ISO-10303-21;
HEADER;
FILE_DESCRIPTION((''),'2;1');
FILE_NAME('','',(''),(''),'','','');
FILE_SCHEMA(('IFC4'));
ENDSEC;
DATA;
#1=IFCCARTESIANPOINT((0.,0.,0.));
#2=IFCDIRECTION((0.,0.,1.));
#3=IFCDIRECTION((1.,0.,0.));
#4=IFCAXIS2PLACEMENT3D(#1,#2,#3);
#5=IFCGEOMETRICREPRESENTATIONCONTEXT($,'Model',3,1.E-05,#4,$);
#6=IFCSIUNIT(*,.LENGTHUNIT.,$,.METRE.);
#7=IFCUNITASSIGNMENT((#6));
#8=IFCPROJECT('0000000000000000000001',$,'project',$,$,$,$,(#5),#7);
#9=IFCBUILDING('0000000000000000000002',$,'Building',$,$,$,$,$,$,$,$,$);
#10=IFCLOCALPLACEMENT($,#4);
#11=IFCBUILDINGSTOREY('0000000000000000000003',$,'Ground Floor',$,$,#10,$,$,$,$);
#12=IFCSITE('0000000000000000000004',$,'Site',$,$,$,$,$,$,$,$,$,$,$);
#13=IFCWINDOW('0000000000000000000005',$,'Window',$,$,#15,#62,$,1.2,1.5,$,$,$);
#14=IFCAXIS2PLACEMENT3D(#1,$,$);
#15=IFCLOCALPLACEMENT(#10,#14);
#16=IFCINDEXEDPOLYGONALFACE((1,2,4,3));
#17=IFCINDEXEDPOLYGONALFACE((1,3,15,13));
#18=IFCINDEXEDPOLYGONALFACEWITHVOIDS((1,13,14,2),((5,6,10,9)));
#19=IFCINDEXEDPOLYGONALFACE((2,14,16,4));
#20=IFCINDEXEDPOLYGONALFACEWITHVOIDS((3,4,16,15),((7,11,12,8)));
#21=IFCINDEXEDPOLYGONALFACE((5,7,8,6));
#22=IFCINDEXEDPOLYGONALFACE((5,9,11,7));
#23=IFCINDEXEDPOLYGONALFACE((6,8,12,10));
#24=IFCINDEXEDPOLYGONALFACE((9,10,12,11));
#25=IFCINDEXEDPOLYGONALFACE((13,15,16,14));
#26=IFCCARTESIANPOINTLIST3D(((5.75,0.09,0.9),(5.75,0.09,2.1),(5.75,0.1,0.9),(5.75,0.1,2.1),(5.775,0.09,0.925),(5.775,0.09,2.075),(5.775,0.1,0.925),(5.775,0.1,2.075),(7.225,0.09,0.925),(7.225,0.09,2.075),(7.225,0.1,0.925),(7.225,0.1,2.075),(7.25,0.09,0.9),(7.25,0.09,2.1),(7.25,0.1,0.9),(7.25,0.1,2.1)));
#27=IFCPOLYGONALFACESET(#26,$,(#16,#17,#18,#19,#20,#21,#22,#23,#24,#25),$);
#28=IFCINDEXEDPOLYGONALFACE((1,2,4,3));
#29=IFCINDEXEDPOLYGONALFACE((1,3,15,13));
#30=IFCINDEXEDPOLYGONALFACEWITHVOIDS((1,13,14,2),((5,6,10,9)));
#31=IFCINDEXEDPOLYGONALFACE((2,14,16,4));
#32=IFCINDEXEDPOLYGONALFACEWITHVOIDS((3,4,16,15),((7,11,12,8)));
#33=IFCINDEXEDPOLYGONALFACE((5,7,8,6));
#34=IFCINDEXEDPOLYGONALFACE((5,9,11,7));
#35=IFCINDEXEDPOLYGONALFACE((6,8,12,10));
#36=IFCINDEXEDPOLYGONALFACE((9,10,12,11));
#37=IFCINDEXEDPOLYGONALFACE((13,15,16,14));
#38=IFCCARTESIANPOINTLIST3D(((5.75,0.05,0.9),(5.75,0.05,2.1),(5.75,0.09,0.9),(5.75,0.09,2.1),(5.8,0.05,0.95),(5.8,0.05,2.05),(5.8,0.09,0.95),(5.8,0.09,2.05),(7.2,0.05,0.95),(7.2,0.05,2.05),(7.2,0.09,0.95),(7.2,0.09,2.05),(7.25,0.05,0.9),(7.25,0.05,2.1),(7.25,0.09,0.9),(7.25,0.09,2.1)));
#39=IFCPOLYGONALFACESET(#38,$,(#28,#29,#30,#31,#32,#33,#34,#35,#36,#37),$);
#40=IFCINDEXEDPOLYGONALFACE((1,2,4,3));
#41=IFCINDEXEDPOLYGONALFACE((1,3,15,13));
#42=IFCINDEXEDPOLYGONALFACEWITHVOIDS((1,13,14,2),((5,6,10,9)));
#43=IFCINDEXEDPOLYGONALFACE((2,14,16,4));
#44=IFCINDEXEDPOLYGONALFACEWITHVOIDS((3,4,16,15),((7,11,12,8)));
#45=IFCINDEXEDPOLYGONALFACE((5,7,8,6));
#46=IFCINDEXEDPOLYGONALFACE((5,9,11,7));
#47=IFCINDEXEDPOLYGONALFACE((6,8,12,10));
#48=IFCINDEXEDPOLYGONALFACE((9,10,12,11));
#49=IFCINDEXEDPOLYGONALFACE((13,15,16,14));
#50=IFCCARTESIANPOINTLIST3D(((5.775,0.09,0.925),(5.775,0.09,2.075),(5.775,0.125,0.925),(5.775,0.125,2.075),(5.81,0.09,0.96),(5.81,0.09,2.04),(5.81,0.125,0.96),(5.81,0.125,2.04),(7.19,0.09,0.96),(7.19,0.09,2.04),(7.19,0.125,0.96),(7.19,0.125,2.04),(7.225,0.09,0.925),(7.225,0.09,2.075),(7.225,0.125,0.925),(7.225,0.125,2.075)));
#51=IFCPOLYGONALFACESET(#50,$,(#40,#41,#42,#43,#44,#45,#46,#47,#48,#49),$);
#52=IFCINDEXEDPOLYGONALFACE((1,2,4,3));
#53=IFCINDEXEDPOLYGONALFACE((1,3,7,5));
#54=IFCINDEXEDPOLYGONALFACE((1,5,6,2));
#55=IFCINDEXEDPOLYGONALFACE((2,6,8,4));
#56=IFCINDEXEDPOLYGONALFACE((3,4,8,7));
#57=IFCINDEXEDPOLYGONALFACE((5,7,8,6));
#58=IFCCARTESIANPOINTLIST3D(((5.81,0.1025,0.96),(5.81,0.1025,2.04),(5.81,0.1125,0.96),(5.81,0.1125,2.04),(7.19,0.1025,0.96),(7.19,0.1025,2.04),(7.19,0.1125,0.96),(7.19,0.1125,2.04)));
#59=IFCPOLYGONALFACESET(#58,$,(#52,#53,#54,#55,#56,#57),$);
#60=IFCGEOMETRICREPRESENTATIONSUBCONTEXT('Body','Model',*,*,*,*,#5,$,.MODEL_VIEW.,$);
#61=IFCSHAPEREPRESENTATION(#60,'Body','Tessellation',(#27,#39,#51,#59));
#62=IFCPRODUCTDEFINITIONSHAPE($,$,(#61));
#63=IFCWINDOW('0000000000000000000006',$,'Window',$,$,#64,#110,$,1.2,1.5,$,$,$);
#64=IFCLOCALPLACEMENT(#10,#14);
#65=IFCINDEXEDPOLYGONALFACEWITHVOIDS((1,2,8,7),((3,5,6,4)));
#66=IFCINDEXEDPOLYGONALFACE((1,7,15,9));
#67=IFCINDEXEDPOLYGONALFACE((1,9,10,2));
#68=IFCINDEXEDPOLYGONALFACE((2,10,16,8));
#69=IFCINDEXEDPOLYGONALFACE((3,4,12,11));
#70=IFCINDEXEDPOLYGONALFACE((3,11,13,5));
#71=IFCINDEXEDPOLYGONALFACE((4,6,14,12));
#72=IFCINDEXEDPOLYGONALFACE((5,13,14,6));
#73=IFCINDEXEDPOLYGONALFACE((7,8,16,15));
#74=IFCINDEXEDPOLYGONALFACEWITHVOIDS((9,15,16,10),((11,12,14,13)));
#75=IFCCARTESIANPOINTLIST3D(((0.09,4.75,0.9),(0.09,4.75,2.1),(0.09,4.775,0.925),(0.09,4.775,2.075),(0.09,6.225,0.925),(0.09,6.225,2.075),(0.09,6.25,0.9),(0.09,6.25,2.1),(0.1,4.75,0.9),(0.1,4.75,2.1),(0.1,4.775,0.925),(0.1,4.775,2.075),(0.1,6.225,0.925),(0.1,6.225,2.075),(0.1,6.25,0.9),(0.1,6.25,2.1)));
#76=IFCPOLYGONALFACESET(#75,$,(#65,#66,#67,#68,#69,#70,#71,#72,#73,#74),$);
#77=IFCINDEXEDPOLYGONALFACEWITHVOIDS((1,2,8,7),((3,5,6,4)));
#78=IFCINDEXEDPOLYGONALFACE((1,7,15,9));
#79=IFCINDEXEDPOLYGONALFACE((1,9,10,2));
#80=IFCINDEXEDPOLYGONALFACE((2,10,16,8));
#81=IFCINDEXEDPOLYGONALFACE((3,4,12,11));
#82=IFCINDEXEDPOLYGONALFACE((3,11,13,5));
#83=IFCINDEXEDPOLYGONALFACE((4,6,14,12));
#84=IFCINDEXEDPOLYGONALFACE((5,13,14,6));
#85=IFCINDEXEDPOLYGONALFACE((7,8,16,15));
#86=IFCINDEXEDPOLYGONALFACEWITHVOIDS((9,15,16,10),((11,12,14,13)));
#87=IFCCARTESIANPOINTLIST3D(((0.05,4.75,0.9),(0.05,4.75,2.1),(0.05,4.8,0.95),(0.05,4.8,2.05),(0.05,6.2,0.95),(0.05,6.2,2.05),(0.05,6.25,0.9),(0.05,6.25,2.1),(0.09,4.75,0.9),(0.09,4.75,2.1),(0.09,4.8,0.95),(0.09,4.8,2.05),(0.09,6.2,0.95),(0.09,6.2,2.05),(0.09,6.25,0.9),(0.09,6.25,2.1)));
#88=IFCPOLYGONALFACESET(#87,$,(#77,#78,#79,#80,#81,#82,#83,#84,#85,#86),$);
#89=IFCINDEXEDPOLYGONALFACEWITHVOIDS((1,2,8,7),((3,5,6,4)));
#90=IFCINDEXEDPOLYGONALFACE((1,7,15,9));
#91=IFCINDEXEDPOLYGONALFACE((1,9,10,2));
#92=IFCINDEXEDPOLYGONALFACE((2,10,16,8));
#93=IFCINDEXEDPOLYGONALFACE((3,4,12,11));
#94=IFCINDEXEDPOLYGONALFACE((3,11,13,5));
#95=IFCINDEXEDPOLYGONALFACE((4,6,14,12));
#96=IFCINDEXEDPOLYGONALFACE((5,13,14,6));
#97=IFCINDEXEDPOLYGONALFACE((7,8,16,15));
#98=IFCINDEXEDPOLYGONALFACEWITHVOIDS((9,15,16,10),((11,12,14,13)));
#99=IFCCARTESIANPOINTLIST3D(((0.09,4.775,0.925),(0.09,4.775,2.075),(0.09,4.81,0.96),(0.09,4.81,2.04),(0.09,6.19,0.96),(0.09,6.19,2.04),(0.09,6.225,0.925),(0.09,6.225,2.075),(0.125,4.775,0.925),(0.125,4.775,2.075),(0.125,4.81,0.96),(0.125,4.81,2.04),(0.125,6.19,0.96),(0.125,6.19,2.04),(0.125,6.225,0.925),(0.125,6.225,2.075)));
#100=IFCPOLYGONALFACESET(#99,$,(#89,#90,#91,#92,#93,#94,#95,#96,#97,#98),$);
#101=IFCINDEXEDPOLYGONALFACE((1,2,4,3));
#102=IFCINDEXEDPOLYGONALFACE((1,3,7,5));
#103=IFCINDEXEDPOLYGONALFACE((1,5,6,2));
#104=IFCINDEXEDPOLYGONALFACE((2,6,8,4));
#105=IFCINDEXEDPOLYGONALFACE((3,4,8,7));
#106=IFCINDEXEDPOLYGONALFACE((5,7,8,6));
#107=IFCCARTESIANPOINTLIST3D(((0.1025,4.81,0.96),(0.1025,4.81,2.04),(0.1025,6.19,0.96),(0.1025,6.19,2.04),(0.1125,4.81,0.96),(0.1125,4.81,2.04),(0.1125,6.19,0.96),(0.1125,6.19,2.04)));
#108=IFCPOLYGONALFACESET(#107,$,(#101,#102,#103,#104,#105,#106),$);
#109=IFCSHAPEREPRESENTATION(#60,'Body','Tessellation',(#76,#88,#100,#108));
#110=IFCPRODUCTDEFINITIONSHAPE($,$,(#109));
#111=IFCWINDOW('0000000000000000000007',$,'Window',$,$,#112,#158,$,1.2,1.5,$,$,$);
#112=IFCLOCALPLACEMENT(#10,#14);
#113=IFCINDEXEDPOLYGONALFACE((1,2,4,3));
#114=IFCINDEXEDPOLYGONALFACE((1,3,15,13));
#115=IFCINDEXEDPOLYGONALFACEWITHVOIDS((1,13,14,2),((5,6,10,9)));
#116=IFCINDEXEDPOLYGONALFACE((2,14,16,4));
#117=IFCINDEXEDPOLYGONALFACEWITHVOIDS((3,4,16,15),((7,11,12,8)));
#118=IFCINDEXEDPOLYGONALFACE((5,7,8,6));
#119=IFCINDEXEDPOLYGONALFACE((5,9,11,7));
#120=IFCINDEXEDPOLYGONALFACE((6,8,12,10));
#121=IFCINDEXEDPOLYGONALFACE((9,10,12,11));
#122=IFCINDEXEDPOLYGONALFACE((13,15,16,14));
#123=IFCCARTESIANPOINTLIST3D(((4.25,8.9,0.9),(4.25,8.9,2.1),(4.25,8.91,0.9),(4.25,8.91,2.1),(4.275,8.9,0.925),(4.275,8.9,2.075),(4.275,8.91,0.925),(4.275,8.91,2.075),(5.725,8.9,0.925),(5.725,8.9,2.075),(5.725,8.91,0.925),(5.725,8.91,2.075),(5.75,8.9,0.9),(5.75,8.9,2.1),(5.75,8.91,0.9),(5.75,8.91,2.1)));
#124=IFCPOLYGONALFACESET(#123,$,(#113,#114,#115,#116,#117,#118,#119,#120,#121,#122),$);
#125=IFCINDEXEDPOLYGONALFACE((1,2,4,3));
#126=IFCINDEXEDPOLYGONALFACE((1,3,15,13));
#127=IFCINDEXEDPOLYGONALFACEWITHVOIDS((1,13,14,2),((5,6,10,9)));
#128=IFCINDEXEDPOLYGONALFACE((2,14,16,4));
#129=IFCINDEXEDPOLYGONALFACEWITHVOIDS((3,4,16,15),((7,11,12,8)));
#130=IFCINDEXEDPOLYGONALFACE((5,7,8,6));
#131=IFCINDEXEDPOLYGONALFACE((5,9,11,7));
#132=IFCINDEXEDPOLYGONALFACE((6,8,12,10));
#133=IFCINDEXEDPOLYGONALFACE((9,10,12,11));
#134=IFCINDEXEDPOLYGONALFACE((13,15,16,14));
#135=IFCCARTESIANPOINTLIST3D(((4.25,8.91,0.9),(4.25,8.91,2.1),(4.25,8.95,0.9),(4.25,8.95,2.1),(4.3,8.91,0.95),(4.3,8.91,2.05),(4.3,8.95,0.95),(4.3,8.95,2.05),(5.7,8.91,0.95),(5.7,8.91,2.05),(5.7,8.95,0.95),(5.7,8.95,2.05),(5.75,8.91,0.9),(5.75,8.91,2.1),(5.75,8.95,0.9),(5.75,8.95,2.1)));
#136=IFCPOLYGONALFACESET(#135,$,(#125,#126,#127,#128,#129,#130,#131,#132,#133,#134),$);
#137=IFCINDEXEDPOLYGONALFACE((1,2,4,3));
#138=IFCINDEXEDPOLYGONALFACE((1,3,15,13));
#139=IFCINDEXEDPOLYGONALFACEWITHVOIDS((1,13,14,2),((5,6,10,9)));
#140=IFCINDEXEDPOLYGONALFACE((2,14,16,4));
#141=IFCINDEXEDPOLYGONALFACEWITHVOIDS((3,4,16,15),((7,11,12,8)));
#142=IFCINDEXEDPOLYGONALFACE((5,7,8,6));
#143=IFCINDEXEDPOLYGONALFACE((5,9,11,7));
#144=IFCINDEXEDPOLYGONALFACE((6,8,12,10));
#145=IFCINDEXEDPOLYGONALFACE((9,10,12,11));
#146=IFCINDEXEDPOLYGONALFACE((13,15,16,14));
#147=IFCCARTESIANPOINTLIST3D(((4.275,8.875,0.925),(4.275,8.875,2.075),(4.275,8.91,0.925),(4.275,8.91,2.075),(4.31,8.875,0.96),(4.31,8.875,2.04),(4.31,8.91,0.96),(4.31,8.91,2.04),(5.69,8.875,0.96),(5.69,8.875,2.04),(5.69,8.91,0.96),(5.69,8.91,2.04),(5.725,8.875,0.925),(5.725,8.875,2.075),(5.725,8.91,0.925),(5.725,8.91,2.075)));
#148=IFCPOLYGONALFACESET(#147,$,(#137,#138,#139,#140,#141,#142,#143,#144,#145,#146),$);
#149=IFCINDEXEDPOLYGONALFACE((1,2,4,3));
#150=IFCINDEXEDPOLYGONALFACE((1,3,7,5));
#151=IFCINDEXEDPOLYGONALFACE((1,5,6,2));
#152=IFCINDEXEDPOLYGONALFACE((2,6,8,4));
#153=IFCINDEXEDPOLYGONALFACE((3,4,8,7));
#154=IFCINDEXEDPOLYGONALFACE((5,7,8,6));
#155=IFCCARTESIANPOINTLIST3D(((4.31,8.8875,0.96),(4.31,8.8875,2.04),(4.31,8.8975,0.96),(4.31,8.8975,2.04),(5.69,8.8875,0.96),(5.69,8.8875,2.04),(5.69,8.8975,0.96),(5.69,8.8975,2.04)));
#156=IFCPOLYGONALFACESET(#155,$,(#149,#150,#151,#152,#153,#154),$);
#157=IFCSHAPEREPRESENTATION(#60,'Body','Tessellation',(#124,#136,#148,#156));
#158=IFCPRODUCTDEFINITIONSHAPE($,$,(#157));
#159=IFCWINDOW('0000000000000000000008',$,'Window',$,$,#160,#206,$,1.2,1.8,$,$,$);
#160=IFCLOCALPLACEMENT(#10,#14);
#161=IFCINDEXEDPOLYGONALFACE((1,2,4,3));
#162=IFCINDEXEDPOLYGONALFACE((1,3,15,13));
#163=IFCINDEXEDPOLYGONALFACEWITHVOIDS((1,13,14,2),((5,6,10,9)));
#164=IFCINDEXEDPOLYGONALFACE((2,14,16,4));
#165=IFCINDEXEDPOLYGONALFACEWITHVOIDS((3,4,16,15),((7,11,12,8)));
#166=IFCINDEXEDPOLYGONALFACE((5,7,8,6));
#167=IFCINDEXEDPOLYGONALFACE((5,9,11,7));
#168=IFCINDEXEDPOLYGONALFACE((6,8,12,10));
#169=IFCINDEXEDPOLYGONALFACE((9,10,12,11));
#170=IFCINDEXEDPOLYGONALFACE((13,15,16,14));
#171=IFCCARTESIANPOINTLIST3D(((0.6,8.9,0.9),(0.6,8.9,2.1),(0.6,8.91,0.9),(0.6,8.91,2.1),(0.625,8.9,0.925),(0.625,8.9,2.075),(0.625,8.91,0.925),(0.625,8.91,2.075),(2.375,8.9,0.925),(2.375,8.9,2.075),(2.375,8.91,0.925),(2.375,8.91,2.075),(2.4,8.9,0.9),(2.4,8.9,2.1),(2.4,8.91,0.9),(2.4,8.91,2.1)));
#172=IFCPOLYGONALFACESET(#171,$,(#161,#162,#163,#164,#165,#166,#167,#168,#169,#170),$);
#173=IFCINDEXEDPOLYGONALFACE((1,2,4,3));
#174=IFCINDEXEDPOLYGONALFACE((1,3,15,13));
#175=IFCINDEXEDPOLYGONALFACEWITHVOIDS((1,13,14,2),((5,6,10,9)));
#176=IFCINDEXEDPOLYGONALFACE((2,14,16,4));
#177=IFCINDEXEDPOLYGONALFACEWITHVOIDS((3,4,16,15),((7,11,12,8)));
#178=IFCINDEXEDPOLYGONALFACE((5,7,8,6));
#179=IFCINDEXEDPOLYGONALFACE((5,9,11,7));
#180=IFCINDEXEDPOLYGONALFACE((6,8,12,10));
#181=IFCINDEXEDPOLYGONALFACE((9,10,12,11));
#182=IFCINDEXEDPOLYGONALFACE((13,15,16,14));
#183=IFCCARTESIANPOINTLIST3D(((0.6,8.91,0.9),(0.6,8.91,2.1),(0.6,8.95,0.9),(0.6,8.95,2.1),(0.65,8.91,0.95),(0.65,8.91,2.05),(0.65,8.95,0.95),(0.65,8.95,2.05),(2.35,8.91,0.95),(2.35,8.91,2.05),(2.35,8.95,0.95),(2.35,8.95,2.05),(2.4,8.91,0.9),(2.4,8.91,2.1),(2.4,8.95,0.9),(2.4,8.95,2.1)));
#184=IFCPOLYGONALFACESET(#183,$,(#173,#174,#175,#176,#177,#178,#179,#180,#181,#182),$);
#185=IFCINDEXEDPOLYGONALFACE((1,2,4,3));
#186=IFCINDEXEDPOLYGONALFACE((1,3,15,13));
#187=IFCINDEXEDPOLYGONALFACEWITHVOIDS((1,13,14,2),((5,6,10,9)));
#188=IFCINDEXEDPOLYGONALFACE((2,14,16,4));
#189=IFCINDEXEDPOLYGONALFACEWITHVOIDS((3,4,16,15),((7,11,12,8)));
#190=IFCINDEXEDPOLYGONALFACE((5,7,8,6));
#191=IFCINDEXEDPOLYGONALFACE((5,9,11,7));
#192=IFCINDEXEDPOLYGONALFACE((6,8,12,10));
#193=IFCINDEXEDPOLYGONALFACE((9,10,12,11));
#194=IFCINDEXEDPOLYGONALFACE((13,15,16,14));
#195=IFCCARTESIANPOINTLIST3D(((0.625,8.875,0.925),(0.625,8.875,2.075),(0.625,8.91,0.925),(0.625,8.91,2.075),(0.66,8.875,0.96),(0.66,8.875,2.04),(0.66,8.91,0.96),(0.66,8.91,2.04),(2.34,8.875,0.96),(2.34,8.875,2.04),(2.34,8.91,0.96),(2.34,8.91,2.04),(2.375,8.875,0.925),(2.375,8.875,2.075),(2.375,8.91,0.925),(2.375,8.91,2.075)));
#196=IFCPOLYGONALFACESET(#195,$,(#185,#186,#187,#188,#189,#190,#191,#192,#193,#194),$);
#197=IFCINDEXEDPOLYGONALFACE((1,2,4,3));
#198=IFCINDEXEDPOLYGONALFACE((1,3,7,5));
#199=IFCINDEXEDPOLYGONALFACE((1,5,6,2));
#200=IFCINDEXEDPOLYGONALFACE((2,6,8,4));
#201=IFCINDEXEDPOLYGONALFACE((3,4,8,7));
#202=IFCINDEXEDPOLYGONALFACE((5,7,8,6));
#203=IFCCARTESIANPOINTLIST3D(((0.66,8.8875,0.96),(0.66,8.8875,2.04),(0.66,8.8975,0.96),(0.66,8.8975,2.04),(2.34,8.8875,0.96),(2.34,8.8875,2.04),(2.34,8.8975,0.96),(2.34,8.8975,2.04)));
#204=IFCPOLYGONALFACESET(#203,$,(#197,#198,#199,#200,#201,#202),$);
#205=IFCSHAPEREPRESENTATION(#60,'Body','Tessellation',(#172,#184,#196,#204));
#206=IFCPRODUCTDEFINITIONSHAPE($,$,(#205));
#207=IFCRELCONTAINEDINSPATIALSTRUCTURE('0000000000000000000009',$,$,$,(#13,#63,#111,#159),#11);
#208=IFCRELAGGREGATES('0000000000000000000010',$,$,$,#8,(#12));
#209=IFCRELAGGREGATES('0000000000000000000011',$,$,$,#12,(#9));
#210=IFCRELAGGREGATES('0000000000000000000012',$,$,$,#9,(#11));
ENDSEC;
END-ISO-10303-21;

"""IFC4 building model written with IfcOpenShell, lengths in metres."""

from ifc_helpers import new_model, si_unit, frame, origin_with_axes, place, context, subcontext, project, spatial, line, indexed_curve, outline, extrude, element, save


model = new_model("IFC4")

# Units and contexts
model_context = context("Model", 3, precision=1e-05, world=origin_with_axes())
body_context = subcontext(model_context, "Body", "Model", "MODEL_VIEW")
ifc_project = project(units=[si_unit("LENGTHUNIT", "METRE")], contexts=[model_context])

# Site, building, storey
site = spatial("IfcSite", under=ifc_project, Name="Site")
building = spatial("IfcBuilding", under=site, Name="Building")
storey_placement = place(None, origin_with_axes())
storey = spatial("IfcBuildingStorey", under=building, at=storey_placement, Name="Ground Floor")

# Windows
for number, where, z_axis, x_axis, name in (
    (1, (5.75, 0.0, 0.9), (0.0, 0.0, 1.0), (1.0, 0.0, 0.0), "Window"),
    (2, (0.0, 6.25, 0.9), (0.0, 0.0, 1.0), (0.0, -1.0, 0.0), "Window"),
    (3, (5.75, 9.0, 0.9), (0.0, 0.0, 1.0), (-1.0, 0.0, 0.0), "Window"),
):
    element("IfcWindow", number, at=place(storey_placement, frame(where, z_axis=z_axis, x_axis=x_axis)), inside=storey, Name=name, OverallHeight=1.2, OverallWidth=1.5, context=body_context, shape_type="SweptSolid", body=[
        extrude(outline(indexed_curve([(0.0, 0.0), (1.5, 0.0), (1.5, 1.2), (0.0, 1.2)], segments=[line(1, 2, 3, 4, 1)]), holes=[indexed_curve([(0.025, 0.025), (1.475, 0.025), (1.475, 1.175), (0.025, 1.175)], segments=[line(1, 2, 3, 4, 1)])]), frame((0.0, 0.09, 0.0), z_axis=(0.0, -1.0, 0.0), x_axis=(1.0, 0.0, 0.0)), (0.0, 0.0, -1.0), 0.01),
        extrude(outline(indexed_curve([(0.0, 0.0), (1.5, 0.0), (1.5, 1.2), (0.0, 1.2)], segments=[line(1, 2, 3, 4, 1)]), holes=[indexed_curve([(0.05, 0.05), (1.45, 0.05), (1.45, 1.15), (0.05, 1.15)], segments=[line(1, 2, 3, 4, 1)])]), frame((0.0, 0.05, 0.0), z_axis=(0.0, -1.0, 0.0), x_axis=(1.0, 0.0, 0.0)), (0.0, 0.0, -1.0), 0.04),
        extrude(outline(indexed_curve([(0.0, 0.0), (1.45, 0.0), (1.45, 1.15), (0.0, 1.15)], segments=[line(1, 2, 3, 4, 1)]), holes=[indexed_curve([(0.035, 0.035), (1.415, 0.035), (1.415, 1.115), (0.035, 1.115)], segments=[line(1, 2, 3, 4, 1)])]), frame((0.025, 0.09, 0.025), z_axis=(0.0, -1.0, 0.0), x_axis=(1.0, 0.0, 0.0)), (0.0, 0.0, -1.0), 0.035),
        extrude(outline(indexed_curve([(0.035, 0.035), (1.415, 0.035), (1.415, 1.115), (0.035, 1.115)], segments=[line(1, 2, 3, 4, 1)])), frame((0.025, 0.1025, 0.025), z_axis=(0.0, -1.0, 0.0), x_axis=(1.0, 0.0, 0.0)), (0.0, 0.0, -1.0), 0.01),
    ])
window_1_placement = place(storey_placement, frame((2.4, 9.0, 0.9), z_axis=(0.0, 0.0, 1.0), x_axis=(-1.0, 0.0, 0.0)))
element("IfcWindow", 4, at=window_1_placement, inside=storey, Name="Window", OverallHeight=1.2, OverallWidth=1.8, context=body_context, shape_type="SweptSolid", body=[
    extrude(outline(indexed_curve([(0.0, 0.0), (1.8, 0.0), (1.8, 1.2), (0.0, 1.2)], segments=[line(1, 2, 3, 4, 1)]), holes=[indexed_curve([(0.025, 0.025), (1.775, 0.025), (1.775, 1.175), (0.025, 1.175)], segments=[line(1, 2, 3, 4, 1)])]), frame((0.0, 0.09, 0.0), z_axis=(0.0, -1.0, 0.0), x_axis=(1.0, 0.0, 0.0)), (0.0, 0.0, -1.0), 0.01),
    extrude(outline(indexed_curve([(0.0, 0.0), (1.8, 0.0), (1.8, 1.2), (0.0, 1.2)], segments=[line(1, 2, 3, 4, 1)]), holes=[indexed_curve([(0.05, 0.05), (1.75, 0.05), (1.75, 1.15), (0.05, 1.15)], segments=[line(1, 2, 3, 4, 1)])]), frame((0.0, 0.05, 0.0), z_axis=(0.0, -1.0, 0.0), x_axis=(1.0, 0.0, 0.0)), (0.0, 0.0, -1.0), 0.04),
    extrude(outline(indexed_curve([(0.0, 0.0), (1.75, 0.0), (1.75, 1.15), (0.0, 1.15)], segments=[line(1, 2, 3, 4, 1)]), holes=[indexed_curve([(0.035, 0.035), (1.715, 0.035), (1.715, 1.115), (0.035, 1.115)], segments=[line(1, 2, 3, 4, 1)])]), frame((0.025, 0.09, 0.025), z_axis=(0.0, -1.0, 0.0), x_axis=(1.0, 0.0, 0.0)), (0.0, 0.0, -1.0), 0.035),
    extrude(outline(indexed_curve([(0.035, 0.035), (1.715, 0.035), (1.715, 1.115), (0.035, 1.115)], segments=[line(1, 2, 3, 4, 1)])), frame((0.025, 0.1025, 0.025), z_axis=(0.0, -1.0, 0.0), x_axis=(1.0, 0.0, 0.0)), (0.0, 0.0, -1.0), 0.01),
])

save(model, "model.ifc")
